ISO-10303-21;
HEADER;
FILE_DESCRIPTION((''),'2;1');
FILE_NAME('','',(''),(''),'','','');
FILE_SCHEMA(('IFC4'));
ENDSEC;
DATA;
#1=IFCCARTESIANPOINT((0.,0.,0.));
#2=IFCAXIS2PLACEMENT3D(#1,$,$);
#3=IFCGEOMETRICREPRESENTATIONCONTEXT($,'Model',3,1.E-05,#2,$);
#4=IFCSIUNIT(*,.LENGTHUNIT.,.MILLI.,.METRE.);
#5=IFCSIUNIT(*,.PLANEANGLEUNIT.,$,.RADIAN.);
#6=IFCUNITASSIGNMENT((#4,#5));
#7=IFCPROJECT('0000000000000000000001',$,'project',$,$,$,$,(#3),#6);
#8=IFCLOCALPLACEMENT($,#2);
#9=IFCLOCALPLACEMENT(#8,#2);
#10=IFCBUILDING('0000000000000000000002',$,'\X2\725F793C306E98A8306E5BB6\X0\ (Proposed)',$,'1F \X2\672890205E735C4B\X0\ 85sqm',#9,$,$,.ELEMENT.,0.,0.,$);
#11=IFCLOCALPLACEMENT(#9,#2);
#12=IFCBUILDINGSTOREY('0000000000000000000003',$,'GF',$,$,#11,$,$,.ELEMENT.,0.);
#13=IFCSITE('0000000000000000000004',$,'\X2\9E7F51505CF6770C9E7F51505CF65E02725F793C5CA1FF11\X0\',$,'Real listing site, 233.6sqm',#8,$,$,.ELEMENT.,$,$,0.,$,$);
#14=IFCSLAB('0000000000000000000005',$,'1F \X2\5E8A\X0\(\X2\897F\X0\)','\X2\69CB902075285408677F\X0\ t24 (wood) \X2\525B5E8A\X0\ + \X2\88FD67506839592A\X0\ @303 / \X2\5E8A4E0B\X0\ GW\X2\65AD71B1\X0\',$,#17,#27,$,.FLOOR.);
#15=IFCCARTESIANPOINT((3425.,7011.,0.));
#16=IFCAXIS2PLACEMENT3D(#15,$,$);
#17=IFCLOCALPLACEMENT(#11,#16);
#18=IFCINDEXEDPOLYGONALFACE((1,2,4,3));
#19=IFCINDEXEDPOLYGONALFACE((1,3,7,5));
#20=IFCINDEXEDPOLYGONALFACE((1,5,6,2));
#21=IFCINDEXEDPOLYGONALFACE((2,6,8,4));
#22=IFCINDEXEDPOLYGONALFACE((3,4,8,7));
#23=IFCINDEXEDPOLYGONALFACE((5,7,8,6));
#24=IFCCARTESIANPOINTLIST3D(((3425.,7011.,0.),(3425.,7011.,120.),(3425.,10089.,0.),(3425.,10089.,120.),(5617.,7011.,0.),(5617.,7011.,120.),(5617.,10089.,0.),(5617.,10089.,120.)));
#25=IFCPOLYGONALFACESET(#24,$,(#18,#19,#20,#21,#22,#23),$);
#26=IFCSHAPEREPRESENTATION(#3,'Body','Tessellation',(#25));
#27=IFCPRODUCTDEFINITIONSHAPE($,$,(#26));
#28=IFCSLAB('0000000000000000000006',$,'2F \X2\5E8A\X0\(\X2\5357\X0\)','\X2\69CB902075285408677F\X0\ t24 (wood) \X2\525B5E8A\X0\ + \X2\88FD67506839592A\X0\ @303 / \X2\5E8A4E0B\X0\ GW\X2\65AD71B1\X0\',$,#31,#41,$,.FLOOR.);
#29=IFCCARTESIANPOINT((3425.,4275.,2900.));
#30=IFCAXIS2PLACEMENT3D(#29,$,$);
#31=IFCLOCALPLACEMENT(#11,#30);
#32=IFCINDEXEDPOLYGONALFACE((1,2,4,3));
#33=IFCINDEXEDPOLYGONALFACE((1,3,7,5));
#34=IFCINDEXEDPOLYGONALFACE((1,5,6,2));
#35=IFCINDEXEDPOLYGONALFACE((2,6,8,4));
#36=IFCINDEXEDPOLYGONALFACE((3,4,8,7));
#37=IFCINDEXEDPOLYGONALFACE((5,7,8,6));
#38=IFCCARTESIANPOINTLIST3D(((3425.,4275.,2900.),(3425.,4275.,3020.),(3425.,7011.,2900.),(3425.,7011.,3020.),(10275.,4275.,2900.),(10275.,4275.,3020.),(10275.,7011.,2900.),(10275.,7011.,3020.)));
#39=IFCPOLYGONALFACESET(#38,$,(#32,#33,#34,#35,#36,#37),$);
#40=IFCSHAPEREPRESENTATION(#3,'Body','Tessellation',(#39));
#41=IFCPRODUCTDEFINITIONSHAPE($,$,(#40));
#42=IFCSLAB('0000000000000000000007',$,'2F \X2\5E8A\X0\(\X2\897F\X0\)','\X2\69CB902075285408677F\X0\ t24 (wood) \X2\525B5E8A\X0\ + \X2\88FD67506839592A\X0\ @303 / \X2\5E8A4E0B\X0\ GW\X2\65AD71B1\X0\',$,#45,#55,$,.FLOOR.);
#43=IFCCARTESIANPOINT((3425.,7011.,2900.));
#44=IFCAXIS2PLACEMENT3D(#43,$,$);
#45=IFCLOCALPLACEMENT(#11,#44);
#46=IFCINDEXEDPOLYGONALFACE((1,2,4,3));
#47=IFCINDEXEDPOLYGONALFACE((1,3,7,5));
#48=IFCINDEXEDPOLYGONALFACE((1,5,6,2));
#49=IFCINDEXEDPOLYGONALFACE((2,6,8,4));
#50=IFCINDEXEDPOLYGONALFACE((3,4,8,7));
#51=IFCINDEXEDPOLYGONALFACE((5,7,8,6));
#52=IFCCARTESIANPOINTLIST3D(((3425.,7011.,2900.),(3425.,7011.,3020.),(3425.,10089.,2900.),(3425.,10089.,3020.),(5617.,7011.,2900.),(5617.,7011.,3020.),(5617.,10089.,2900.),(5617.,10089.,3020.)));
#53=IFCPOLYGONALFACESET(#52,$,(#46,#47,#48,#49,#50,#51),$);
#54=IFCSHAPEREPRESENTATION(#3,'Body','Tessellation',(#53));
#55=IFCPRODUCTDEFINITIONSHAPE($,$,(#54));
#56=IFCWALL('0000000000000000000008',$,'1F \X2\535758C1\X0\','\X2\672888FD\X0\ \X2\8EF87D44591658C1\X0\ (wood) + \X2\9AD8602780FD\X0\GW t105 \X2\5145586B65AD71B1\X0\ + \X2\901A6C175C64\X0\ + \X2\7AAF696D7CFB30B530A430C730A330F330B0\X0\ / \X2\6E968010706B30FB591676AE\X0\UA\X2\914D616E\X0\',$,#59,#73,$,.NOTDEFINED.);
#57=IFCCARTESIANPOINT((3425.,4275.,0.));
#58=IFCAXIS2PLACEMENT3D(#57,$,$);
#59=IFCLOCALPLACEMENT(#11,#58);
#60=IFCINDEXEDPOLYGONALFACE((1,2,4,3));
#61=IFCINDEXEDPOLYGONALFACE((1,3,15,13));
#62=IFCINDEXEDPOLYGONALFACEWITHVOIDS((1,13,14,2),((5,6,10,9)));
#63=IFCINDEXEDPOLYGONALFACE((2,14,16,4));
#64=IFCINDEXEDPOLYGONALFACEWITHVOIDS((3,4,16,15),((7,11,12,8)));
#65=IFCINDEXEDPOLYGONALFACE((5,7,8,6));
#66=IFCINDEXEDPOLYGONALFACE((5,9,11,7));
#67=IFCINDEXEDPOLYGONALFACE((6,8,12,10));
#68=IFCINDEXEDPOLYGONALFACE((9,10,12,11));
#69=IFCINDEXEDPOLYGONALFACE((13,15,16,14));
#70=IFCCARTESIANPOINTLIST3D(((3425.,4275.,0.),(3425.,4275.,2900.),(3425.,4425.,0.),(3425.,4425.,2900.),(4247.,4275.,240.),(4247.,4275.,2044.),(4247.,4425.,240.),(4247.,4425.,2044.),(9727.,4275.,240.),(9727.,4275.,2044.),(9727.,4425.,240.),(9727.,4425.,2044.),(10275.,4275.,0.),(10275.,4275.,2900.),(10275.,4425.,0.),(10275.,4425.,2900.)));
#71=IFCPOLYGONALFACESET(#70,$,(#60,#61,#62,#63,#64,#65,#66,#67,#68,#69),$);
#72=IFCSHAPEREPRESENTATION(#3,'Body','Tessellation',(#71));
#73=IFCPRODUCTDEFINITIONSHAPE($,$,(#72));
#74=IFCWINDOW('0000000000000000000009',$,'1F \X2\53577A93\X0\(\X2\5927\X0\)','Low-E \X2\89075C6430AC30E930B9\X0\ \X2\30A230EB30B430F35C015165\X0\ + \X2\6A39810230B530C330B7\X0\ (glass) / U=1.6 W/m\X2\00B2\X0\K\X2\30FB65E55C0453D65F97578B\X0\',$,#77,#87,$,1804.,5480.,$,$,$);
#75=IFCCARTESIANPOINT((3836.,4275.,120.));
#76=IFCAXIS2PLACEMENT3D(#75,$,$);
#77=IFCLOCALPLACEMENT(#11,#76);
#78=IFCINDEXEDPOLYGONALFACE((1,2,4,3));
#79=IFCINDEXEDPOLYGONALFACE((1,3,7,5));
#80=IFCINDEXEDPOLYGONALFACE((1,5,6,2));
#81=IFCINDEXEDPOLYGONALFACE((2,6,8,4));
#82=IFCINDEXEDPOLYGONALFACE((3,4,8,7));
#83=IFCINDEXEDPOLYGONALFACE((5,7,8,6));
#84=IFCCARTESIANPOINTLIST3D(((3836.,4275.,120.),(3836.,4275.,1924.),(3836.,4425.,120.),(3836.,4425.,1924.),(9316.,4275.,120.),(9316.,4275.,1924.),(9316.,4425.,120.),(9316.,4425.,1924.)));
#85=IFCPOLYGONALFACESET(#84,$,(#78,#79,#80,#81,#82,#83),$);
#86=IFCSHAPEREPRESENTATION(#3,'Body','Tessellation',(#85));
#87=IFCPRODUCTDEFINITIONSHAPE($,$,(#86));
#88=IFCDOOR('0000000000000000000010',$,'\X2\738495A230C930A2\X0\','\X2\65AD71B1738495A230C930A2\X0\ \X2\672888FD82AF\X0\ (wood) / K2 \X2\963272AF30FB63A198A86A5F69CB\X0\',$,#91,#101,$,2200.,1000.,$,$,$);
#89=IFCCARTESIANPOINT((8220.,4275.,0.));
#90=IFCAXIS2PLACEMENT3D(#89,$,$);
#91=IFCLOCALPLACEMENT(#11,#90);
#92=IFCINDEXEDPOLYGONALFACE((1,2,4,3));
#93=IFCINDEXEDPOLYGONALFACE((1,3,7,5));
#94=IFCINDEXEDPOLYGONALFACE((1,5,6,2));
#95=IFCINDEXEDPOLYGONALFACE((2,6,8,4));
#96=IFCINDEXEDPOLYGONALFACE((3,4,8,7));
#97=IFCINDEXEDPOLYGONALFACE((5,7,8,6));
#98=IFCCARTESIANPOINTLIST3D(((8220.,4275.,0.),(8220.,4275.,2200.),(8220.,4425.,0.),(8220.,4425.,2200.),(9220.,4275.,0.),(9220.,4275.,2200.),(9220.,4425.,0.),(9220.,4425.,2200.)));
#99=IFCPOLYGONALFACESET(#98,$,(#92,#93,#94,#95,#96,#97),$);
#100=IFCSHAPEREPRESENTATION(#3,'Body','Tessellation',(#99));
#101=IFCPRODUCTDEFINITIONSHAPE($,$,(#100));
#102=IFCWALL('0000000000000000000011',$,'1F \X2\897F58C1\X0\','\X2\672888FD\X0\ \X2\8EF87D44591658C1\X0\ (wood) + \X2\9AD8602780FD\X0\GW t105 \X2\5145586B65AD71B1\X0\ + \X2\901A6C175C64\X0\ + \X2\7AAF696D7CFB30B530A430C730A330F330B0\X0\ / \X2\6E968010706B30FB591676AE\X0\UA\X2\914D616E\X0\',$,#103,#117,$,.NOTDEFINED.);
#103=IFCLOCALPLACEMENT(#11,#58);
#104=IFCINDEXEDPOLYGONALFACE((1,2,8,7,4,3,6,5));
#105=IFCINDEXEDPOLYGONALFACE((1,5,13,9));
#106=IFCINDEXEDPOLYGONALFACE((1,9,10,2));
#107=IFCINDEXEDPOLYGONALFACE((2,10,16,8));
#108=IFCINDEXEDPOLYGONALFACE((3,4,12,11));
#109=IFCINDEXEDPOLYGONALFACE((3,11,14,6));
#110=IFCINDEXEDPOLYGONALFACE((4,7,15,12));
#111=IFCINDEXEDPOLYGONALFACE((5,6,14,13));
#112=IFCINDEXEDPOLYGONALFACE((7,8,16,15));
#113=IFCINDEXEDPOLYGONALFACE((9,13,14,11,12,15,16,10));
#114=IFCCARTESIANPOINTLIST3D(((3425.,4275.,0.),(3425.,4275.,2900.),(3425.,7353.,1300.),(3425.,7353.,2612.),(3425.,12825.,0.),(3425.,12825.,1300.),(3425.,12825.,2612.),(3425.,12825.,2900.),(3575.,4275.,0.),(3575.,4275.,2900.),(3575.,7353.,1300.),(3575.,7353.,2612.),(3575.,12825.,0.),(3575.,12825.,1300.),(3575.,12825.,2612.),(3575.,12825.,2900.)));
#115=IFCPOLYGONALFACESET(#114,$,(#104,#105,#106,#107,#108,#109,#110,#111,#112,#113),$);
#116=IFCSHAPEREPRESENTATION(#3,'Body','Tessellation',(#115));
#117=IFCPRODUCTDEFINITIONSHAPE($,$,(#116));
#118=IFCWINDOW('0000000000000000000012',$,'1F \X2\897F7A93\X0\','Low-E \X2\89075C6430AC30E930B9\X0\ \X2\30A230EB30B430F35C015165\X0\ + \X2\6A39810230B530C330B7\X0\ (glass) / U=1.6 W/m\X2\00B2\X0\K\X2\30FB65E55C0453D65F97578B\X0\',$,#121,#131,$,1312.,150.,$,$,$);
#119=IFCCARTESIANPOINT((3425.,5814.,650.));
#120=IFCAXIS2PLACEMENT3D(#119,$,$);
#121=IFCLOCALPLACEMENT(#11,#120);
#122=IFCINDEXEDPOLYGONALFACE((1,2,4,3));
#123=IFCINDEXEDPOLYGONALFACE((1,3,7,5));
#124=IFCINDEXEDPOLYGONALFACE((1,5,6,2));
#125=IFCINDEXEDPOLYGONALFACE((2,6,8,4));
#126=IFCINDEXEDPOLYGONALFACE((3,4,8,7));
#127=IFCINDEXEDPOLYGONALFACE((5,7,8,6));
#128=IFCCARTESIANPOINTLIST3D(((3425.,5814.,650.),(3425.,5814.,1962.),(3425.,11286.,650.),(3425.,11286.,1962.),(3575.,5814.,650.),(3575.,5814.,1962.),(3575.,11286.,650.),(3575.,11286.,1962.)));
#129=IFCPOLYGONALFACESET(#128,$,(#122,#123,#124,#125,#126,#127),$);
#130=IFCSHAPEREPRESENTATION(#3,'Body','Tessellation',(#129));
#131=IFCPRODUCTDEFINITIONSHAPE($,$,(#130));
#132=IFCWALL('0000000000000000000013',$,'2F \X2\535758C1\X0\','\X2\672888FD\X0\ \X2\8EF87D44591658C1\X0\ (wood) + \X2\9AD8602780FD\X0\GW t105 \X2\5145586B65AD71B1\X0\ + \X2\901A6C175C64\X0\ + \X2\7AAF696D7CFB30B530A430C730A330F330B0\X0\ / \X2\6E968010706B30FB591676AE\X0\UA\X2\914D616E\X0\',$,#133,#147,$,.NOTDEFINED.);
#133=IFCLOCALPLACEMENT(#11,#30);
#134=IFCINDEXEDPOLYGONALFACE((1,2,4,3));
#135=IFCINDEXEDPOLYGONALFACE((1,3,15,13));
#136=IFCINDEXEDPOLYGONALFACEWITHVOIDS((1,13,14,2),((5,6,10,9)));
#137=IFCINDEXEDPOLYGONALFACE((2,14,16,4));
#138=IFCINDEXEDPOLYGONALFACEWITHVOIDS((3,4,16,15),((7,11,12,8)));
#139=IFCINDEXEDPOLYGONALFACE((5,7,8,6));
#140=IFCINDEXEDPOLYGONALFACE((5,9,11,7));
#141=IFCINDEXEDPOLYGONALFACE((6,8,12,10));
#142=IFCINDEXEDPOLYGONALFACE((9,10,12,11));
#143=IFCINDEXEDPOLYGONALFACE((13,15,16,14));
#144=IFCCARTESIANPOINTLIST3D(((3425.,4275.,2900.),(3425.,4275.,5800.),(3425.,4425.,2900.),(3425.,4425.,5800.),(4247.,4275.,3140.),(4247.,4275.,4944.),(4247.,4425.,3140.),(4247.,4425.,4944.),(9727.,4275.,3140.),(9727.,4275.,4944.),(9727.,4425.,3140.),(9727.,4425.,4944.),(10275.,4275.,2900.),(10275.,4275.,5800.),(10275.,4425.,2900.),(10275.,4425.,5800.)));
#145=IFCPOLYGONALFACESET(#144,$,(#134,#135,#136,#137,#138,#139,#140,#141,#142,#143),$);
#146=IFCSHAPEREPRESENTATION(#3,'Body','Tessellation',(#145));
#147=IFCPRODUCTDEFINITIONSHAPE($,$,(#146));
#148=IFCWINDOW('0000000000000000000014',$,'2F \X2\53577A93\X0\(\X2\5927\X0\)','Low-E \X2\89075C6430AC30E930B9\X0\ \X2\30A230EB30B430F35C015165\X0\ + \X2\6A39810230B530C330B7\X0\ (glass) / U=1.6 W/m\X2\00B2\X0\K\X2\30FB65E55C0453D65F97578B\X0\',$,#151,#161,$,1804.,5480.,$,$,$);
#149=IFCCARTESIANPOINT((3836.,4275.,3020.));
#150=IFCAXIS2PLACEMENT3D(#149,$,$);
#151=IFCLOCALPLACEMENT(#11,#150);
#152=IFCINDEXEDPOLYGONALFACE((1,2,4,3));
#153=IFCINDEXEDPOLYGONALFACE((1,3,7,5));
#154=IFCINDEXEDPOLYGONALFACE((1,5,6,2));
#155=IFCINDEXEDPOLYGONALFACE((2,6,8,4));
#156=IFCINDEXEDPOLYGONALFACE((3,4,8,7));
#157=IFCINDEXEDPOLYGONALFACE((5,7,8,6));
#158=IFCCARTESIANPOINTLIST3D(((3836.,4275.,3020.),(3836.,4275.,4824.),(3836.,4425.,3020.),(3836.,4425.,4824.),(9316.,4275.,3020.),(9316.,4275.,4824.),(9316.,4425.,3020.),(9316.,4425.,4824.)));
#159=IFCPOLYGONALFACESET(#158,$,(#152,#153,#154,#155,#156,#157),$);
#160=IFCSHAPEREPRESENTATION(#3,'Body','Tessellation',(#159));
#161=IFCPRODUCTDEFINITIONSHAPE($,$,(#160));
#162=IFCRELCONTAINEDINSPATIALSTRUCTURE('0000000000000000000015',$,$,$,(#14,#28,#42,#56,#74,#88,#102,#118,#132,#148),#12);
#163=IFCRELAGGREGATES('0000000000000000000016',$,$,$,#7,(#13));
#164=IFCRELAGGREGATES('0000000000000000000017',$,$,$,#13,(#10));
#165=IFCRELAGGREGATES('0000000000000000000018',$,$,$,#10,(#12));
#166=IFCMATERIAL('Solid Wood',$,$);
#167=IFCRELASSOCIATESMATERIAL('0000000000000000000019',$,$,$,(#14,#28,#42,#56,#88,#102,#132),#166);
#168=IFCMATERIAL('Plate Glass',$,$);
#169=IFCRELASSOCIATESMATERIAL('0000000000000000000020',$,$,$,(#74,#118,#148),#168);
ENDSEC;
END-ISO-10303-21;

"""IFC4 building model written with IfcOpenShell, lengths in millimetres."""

from ifc_helpers import new_model, si_unit, frame, frame_2d, origin, place, context, project, spatial, rectangle, extrude, material, element, fill, save


model = new_model("IFC4")

# Units and contexts
model_context = context("Model", 3, precision=1e-05, world=origin())
ifc_project = project(units=[si_unit("LENGTHUNIT", "METRE", prefix="MILLI"), si_unit("PLANEANGLEUNIT", "RADIAN")], contexts=[model_context])

# Site, building, storey
site_placement = place(None, origin())
site = spatial("IfcSite", under=ifc_project, at=site_placement, Name="鹿児島県鹿児島市牟礼岡１", ObjectType="Real listing site, 233.6sqm", CompositionType="ELEMENT", RefElevation=0.0)
building_placement = place(site_placement, origin())
building = spatial("IfcBuilding", under=site, at=building_placement, Name="牟礼の風の家 (Proposed)", ObjectType="1F 木造平屋 85sqm", CompositionType="ELEMENT", ElevationOfRefHeight=0.0, ElevationOfTerrain=0.0)
storey_placement = place(building_placement, origin())
storey = spatial("IfcBuildingStorey", under=building, at=storey_placement, Name="GF", CompositionType="ELEMENT", Elevation=0.0)

# Slabs
ifc_material_1 = material(Name="Solid Wood")
slab_1_placement = place(storey_placement, frame((3425.0, 7011.0, 0.0)))
element("IfcSlab", 1, at=slab_1_placement, inside=storey, material=ifc_material_1, Name="1F 床(西)", Description="構造用合板 t24 (wood) 剛床 + 製材根太 @303 / 床下 GW断熱", PredefinedType="FLOOR", context=model_context, shape_type="SweptSolid", body=[
    extrude(rectangle(XDim=2192.0, YDim=3078.0, at=frame_2d((1096.0, 1539.0))), frame((3425.0, 7011.0, 0.0)), (0.0, 0.0, 1.0), 120.0),
])
slab_2_placement = place(storey_placement, frame((3425.0, 4275.0, 2900.0)))
element("IfcSlab", 2, at=slab_2_placement, inside=storey, material=ifc_material_1, Name="2F 床(南)", Description="構造用合板 t24 (wood) 剛床 + 製材根太 @303 / 床下 GW断熱", PredefinedType="FLOOR", context=model_context, shape_type="SweptSolid", body=[
    extrude(rectangle(XDim=6850.0, YDim=2736.0, at=frame_2d((3425.0, 1368.0))), frame((3425.0, 4275.0, 2900.0)), (0.0, 0.0, 1.0), 120.0),
])
slab_3_placement = place(storey_placement, frame((3425.0, 7011.0, 2900.0)))
element("IfcSlab", 3, at=slab_3_placement, inside=storey, material=ifc_material_1, Name="2F 床(西)", Description="構造用合板 t24 (wood) 剛床 + 製材根太 @303 / 床下 GW断熱", PredefinedType="FLOOR", context=model_context, shape_type="SweptSolid", body=[
    extrude(rectangle(XDim=2192.0, YDim=3078.0, at=frame_2d((1096.0, 1539.0))), frame((3425.0, 7011.0, 2900.0)), (0.0, 0.0, 1.0), 120.0),
])

# Wall, openings, window, door
wall_1_placement = place(storey_placement, frame((3425.0, 4275.0, 0.0)))
wall_1 = element("IfcWall", 4, at=wall_1_placement, inside=storey, material=ifc_material_1, Name="1F 南壁", Description="木製 軸組外壁 (wood) + 高性能GW t105 充填断熱 + 通気層 + 窯業系サイディング / 準耐火・外皮UA配慮", PredefinedType="NOTDEFINED", context=model_context, shape_type="SweptSolid", body=[
    extrude(rectangle(XDim=6850.0, YDim=150.0, at=frame_2d((3425.0, 75.0))), frame((3425.0, 4275.0, 0.0)), (0.0, 0.0, 1.0), 2900.0),
])
opening_1_placement = place(storey_placement, frame((3836.0, 4275.0, 120.0)))
opening_1 = element("IfcOpeningElement", 5, at=opening_1_placement, cuts=wall_1, PredefinedType="NOTDEFINED", context=model_context, shape_type="SweptSolid", body=[
    extrude(rectangle(XDim=5480.0, YDim=150.0, at=frame_2d((2740.0, 75.0))), frame((3836.0, 4275.0, 120.0)), (0.0, 0.0, 1.0), 1804.0),
])
opening_2_placement = place(storey_placement, frame((8220.0, 4275.0, 0.0)))
opening_2 = element("IfcOpeningElement", 6, at=opening_2_placement, cuts=wall_1, PredefinedType="NOTDEFINED", context=model_context, shape_type="SweptSolid", body=[
    extrude(rectangle(XDim=1000.0, YDim=150.0, at=frame_2d((500.0, 75.0))), frame((8220.0, 4275.0, 0.0)), (0.0, 0.0, 1.0), 2200.0),
])
ifc_material_2 = material(Name="Plate Glass")
window_1_placement = place(storey_placement, frame((3836.0, 4275.0, 120.0)))
window_1 = element("IfcWindow", 7, at=window_1_placement, inside=storey, material=ifc_material_2, Name="1F 南窓(大)", Description="Low-E 複層ガラス アルゴン封入 + 樹脂サッシ (glass) / U=1.6 W/m²K・日射取得型", OverallHeight=1804.0, OverallWidth=5480.0, context=model_context, shape_type="SweptSolid", body=[
    extrude(rectangle(XDim=5480.0, YDim=150.0, at=frame_2d((2740.0, 75.0))), frame((3836.0, 4275.0, 120.0)), (0.0, 0.0, 1.0), 1804.0),
])
fill(opening_1, window_1)
door_placement = place(storey_placement, frame((8220.0, 4275.0, 0.0)))
door = element("IfcDoor", 8, at=door_placement, inside=storey, material=ifc_material_1, Name="玄関ドア", Description="断熱玄関ドア 木製芯 (wood) / K2 防犯・採風機構", OverallHeight=2200.0, OverallWidth=1000.0, context=model_context, shape_type="SweptSolid", body=[
    extrude(rectangle(XDim=1000.0, YDim=150.0, at=frame_2d((500.0, 75.0))), frame((8220.0, 4275.0, 0.0)), (0.0, 0.0, 1.0), 2200.0),
])
fill(opening_2, door)

# Walls, openings, windows
wall_2_placement = place(storey_placement, frame((3425.0, 4275.0, 0.0)))
wall_2 = element("IfcWall", 9, at=wall_2_placement, inside=storey, material=ifc_material_1, Name="1F 西壁", Description="木製 軸組外壁 (wood) + 高性能GW t105 充填断熱 + 通気層 + 窯業系サイディング / 準耐火・外皮UA配慮", PredefinedType="NOTDEFINED", context=model_context, shape_type="SweptSolid", body=[
    extrude(rectangle(XDim=150.0, YDim=8550.0, at=frame_2d((75.0, 4275.0))), frame((3425.0, 4275.0, 0.0)), (0.0, 0.0, 1.0), 2900.0),
])
opening_3_placement = place(storey_placement, frame((3425.0, 5814.0, 650.0)))
opening_3 = element("IfcOpeningElement", 10, at=opening_3_placement, cuts=wall_2, PredefinedType="NOTDEFINED", context=model_context, shape_type="SweptSolid", body=[
    extrude(rectangle(XDim=150.0, YDim=5472.0, at=frame_2d((75.0, 2736.0))), frame((3425.0, 5814.0, 650.0)), (0.0, 0.0, 1.0), 1312.0),
])
window_2_placement = place(storey_placement, frame((3425.0, 5814.0, 650.0)))
window_2 = element("IfcWindow", 11, at=window_2_placement, inside=storey, material=ifc_material_2, Name="1F 西窓", Description="Low-E 複層ガラス アルゴン封入 + 樹脂サッシ (glass) / U=1.6 W/m²K・日射取得型", OverallHeight=1312.0, OverallWidth=150.0, context=model_context, shape_type="SweptSolid", body=[
    extrude(rectangle(XDim=150.0, YDim=5472.0, at=frame_2d((75.0, 2736.0))), frame((3425.0, 5814.0, 650.0)), (0.0, 0.0, 1.0), 1312.0),
])
fill(opening_3, window_2)
wall_3_placement = place(storey_placement, frame((3425.0, 4275.0, 2900.0)))
wall_3 = element("IfcWall", 12, at=wall_3_placement, inside=storey, material=ifc_material_1, Name="2F 南壁", Description="木製 軸組外壁 (wood) + 高性能GW t105 充填断熱 + 通気層 + 窯業系サイディング / 準耐火・外皮UA配慮", PredefinedType="NOTDEFINED", context=model_context, shape_type="SweptSolid", body=[
    extrude(rectangle(XDim=6850.0, YDim=150.0, at=frame_2d((3425.0, 75.0))), frame((3425.0, 4275.0, 2900.0)), (0.0, 0.0, 1.0), 2900.0),
])
opening_4_placement = place(storey_placement, frame((3836.0, 4275.0, 3020.0)))
opening_4 = element("IfcOpeningElement", 13, at=opening_4_placement, cuts=wall_3, PredefinedType="NOTDEFINED", context=model_context, shape_type="SweptSolid", body=[
    extrude(rectangle(XDim=5480.0, YDim=150.0, at=frame_2d((2740.0, 75.0))), frame((3836.0, 4275.0, 3020.0)), (0.0, 0.0, 1.0), 1804.0),
])
window_3_placement = place(storey_placement, frame((3836.0, 4275.0, 3020.0)))
window_3 = element("IfcWindow", 14, at=window_3_placement, inside=storey, material=ifc_material_2, Name="2F 南窓(大)", Description="Low-E 複層ガラス アルゴン封入 + 樹脂サッシ (glass) / U=1.6 W/m²K・日射取得型", OverallHeight=1804.0, OverallWidth=5480.0, context=model_context, shape_type="SweptSolid", body=[
    extrude(rectangle(XDim=5480.0, YDim=150.0, at=frame_2d((2740.0, 75.0))), frame((3836.0, 4275.0, 3020.0)), (0.0, 0.0, 1.0), 1804.0),
])
fill(opening_4, window_3)

save(model, "model.ifc")
